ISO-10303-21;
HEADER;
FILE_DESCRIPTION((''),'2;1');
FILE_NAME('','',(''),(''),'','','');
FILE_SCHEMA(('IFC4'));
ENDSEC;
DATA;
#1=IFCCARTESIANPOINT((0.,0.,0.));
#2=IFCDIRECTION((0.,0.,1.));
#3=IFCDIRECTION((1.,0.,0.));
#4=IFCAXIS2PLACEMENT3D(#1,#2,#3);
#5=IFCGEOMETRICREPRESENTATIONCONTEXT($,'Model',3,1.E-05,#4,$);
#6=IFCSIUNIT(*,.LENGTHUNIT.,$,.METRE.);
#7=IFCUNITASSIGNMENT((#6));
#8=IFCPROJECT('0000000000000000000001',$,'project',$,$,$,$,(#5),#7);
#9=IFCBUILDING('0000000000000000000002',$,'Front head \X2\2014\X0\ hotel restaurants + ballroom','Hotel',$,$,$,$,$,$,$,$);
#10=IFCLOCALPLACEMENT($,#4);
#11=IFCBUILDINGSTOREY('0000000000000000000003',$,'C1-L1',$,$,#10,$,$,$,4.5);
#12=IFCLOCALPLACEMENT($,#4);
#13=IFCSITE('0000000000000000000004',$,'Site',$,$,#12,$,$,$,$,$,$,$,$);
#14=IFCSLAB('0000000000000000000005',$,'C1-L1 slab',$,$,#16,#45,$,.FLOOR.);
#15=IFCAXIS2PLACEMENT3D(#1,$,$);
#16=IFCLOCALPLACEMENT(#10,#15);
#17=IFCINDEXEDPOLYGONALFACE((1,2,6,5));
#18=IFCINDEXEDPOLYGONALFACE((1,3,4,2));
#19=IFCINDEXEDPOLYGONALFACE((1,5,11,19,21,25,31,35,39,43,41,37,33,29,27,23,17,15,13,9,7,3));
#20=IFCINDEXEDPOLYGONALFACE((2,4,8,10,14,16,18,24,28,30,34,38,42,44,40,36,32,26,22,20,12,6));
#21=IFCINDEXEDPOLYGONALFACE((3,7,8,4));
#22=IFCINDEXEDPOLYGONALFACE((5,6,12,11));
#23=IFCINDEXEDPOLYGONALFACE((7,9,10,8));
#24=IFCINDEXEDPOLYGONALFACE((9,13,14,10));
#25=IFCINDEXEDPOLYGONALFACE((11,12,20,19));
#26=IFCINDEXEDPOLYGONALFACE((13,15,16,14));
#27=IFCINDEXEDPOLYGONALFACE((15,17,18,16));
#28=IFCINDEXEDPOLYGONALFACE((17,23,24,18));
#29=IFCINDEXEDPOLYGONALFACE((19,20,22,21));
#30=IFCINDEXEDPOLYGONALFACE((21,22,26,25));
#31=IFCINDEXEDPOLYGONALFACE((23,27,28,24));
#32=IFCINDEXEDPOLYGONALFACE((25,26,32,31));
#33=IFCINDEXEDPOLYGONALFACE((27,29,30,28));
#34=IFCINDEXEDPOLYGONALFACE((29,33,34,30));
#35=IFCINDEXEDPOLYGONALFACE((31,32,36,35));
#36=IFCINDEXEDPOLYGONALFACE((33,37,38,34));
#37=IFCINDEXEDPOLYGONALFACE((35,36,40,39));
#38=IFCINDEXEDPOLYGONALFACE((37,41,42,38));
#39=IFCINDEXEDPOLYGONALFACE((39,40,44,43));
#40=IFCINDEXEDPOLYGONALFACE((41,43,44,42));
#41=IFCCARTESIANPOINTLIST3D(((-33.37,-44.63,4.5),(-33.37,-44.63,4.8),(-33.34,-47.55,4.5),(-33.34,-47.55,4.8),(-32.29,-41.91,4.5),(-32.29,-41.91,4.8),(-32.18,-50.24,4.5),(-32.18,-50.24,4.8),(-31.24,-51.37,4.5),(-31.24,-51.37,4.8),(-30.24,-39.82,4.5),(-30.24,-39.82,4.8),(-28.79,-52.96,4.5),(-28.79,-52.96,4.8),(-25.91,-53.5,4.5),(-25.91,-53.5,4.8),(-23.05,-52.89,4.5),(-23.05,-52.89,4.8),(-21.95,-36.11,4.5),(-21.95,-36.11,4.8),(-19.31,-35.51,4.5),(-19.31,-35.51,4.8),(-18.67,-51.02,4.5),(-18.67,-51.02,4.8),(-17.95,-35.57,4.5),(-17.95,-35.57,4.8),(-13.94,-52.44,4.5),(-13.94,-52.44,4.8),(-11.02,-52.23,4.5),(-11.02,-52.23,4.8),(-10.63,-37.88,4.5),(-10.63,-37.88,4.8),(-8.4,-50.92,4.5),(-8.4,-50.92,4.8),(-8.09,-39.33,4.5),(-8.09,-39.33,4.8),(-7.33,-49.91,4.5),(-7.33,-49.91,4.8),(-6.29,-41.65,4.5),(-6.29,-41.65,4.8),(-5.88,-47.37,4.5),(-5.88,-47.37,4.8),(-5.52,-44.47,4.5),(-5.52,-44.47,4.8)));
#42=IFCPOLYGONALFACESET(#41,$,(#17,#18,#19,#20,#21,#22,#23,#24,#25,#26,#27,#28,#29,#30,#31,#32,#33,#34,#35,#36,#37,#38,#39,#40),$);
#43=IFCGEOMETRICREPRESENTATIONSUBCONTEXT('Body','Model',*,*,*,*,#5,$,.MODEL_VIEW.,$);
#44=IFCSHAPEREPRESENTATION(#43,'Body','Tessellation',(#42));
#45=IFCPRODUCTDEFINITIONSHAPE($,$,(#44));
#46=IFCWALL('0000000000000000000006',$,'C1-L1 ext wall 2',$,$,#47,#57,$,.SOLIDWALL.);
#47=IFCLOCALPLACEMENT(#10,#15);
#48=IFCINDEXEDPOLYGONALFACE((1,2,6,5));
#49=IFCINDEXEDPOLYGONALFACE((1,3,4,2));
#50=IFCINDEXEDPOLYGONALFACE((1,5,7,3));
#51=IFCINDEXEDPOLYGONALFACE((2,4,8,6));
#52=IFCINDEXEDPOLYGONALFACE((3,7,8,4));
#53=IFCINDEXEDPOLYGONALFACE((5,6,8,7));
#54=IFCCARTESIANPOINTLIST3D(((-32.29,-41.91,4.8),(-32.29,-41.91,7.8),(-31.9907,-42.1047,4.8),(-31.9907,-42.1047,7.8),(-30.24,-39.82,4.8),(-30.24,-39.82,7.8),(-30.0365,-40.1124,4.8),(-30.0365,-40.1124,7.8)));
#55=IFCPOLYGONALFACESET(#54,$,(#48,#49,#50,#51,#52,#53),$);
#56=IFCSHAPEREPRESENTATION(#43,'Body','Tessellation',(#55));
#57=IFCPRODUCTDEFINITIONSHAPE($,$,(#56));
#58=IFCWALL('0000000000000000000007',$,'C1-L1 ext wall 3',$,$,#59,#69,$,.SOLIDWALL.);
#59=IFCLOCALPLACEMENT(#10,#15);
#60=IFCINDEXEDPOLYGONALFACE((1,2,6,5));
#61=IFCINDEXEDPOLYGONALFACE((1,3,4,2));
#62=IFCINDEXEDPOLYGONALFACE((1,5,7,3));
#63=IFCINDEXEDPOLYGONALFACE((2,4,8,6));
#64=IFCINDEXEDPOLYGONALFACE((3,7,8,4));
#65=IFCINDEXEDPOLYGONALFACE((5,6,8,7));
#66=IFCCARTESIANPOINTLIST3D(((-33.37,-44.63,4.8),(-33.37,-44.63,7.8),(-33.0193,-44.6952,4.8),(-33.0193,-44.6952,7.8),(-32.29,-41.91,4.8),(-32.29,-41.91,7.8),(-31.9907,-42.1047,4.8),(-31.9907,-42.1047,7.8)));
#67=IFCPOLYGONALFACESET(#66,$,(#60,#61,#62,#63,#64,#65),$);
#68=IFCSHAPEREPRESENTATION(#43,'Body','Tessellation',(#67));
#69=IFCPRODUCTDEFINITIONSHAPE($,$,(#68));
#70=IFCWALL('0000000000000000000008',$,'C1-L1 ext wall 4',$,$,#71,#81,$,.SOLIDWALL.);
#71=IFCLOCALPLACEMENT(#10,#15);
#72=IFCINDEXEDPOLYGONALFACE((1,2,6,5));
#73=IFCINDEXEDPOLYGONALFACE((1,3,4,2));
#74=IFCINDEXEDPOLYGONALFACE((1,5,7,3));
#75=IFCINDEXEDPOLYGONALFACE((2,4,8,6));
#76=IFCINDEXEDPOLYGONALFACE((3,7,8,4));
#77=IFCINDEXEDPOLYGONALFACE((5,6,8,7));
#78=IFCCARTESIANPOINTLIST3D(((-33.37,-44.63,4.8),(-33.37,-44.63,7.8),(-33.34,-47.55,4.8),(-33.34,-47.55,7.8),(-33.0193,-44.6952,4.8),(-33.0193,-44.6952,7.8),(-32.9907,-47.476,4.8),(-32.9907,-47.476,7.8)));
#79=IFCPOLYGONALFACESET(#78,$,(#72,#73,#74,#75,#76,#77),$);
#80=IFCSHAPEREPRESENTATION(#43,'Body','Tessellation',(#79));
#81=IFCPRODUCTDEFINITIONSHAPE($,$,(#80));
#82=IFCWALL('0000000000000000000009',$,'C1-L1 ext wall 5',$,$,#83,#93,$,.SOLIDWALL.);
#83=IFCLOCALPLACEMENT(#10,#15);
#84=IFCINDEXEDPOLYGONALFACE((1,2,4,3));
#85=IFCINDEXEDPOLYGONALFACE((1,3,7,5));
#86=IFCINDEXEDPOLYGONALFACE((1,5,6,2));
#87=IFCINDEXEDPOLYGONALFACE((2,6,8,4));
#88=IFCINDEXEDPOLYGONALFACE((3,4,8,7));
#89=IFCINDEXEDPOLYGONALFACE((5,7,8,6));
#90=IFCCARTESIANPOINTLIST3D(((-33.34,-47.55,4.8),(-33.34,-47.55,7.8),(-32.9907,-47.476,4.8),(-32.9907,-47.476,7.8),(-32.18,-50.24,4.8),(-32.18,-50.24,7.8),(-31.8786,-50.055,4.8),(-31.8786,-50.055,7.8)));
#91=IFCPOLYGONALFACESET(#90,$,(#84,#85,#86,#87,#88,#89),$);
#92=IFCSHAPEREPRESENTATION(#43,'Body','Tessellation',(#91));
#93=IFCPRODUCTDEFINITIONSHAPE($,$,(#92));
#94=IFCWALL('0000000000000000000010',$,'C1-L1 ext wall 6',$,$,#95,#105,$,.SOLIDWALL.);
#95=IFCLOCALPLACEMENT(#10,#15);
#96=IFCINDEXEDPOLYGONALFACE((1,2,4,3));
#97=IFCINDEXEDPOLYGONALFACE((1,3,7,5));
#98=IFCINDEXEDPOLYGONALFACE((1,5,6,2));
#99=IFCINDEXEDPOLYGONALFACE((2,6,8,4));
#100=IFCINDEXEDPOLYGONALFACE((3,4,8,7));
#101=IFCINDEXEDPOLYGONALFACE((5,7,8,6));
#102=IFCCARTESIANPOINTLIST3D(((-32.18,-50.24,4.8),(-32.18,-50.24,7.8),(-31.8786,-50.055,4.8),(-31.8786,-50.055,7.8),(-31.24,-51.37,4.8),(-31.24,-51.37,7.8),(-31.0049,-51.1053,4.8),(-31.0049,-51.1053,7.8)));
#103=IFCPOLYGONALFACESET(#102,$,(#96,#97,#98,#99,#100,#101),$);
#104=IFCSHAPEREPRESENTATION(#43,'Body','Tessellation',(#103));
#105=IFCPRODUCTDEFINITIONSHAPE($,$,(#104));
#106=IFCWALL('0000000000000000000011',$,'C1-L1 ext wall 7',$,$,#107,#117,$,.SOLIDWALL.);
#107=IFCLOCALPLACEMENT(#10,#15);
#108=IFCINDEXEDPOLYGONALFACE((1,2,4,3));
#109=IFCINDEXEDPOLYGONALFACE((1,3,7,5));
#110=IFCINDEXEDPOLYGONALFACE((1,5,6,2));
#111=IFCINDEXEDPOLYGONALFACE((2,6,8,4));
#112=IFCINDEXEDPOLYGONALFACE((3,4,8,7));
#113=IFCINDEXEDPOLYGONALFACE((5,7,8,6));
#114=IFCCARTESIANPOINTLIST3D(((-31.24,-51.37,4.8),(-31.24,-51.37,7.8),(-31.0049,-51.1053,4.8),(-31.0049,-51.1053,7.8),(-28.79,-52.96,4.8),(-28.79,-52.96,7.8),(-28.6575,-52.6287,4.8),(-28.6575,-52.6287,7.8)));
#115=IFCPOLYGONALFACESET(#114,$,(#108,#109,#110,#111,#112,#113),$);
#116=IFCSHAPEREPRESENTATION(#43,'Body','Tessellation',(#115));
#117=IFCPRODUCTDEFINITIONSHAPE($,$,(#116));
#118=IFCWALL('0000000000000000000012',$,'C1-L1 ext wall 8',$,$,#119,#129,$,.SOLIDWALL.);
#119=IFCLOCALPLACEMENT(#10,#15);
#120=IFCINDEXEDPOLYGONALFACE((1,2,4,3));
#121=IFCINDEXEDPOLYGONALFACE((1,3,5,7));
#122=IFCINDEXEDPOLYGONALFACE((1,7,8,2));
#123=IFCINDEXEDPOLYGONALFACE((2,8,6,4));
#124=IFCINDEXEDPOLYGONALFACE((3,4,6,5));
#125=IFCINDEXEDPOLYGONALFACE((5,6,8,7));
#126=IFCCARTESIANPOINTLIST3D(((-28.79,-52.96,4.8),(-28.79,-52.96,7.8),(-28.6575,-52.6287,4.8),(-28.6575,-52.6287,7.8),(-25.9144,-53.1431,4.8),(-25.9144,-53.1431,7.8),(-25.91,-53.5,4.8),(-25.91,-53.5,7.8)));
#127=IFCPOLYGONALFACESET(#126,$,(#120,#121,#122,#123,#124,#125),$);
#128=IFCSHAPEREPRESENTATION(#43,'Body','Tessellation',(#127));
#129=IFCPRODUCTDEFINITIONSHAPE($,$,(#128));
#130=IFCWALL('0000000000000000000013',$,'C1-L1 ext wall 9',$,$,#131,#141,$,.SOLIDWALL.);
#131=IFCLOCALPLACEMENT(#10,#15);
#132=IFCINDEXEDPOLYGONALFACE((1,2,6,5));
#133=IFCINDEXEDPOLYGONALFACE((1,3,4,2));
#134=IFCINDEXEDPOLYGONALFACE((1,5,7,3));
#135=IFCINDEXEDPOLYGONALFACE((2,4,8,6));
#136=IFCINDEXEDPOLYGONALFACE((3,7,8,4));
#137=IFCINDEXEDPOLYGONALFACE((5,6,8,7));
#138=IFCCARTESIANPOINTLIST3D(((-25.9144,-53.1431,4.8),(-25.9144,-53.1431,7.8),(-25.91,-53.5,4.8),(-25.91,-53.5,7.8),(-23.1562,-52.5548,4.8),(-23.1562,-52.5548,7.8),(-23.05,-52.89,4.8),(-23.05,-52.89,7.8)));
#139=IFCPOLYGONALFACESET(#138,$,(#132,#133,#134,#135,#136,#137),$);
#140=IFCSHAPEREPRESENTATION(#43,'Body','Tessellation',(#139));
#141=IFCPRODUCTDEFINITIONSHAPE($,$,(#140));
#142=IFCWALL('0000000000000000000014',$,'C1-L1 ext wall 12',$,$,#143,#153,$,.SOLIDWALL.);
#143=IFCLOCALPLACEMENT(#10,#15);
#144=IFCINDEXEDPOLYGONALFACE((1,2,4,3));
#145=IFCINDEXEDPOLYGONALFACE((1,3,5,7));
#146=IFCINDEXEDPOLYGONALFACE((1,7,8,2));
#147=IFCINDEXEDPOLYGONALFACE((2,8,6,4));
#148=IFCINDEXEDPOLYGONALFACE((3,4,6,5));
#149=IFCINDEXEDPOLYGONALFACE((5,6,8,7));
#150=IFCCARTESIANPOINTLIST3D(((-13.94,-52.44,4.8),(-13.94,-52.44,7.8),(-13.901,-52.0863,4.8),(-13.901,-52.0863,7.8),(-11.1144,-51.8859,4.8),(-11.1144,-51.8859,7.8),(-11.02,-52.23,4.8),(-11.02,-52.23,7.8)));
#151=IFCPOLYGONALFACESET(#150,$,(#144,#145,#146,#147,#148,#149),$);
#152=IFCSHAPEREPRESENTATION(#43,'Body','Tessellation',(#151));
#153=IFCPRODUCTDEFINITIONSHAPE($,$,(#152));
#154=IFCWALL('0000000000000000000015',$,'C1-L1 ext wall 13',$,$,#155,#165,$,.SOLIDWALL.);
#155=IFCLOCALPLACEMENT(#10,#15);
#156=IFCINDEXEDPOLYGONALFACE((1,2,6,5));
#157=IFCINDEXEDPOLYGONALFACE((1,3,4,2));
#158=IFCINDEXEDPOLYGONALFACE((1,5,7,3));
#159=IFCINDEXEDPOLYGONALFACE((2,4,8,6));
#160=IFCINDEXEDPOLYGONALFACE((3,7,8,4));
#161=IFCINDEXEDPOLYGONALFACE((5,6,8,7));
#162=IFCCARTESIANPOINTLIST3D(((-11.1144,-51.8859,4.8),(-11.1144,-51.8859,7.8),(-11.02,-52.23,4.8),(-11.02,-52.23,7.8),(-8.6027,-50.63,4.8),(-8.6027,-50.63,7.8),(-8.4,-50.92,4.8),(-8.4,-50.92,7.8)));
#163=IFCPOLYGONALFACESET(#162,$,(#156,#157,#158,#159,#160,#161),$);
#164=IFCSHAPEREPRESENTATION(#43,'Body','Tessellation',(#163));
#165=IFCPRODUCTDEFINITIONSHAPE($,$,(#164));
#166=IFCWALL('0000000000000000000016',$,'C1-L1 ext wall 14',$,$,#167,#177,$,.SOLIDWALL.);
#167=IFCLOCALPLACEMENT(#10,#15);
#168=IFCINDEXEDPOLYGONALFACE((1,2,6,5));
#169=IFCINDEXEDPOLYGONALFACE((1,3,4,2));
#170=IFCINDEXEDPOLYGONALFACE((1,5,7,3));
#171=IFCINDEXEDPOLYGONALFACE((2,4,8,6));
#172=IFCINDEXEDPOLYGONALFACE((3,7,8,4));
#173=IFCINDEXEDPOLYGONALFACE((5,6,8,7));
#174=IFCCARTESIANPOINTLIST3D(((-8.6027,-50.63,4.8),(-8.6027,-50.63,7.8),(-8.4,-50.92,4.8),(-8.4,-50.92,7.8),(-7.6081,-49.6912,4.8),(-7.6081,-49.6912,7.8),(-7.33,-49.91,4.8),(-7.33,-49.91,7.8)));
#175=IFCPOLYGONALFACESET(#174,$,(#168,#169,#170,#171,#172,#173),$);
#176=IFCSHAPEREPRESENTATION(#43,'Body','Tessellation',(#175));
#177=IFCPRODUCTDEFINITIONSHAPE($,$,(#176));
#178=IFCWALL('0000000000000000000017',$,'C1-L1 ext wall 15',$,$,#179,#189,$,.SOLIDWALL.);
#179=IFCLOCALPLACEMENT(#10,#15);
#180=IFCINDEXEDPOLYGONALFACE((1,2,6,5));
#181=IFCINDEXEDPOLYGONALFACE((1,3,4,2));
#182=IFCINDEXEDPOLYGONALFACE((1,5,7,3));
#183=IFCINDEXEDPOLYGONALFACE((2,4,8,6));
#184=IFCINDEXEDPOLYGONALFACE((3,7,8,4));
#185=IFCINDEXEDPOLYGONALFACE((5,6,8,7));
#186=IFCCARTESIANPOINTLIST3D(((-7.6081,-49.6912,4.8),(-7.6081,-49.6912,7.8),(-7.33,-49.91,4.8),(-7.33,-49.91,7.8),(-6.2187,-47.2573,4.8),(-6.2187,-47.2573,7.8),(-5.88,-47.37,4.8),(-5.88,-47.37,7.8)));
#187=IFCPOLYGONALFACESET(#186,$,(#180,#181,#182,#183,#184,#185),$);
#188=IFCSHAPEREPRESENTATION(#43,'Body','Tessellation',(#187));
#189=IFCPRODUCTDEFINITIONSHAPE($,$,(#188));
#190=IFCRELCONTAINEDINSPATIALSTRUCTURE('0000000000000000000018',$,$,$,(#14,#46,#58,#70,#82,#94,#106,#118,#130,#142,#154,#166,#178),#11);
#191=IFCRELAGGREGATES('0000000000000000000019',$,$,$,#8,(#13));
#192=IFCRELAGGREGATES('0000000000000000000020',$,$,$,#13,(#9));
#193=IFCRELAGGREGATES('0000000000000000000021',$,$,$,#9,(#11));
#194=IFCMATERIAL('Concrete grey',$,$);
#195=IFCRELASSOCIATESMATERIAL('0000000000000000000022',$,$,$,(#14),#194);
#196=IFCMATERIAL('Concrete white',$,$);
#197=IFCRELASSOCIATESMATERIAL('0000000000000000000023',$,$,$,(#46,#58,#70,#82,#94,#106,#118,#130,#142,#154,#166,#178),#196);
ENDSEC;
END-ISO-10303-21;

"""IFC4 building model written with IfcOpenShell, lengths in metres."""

from ifc_helpers import new_model, si_unit, frame, origin_with_axes, place, context, subcontext, project, spatial, polyline, outline, extrude, material, element, save


model = new_model("IFC4")

# Units and contexts
model_context = context("Model", 3, precision=1e-05, world=origin_with_axes())
body_context = subcontext(model_context, "Body", "Model", "MODEL_VIEW")
ifc_project = project(units=[si_unit("LENGTHUNIT", "METRE")], contexts=[model_context])

# Site, building, storey
site_placement = place(None, origin_with_axes())
site = spatial("IfcSite", under=ifc_project, at=site_placement, Name="Site")
building = spatial("IfcBuilding", under=site, Name="Front head — hotel restaurants + ballroom", Description="Hotel")
storey_placement = place(None, origin_with_axes())
storey = spatial("IfcBuildingStorey", under=building, at=storey_placement, Name="C1-L1", Elevation=4.5)

# Slab
ifc_material_1 = material(Name="Concrete grey")
slab_placement = place(storey_placement, origin_with_axes())
element("IfcSlab", 1, at=slab_placement, inside=storey, material=ifc_material_1, Name="C1-L1 slab", PredefinedType="FLOOR", context=body_context, shape_type="SweptSolid", body=[
    extrude(outline(polyline([(-21.95, -36.11), (-30.24, -39.82), (-32.29, -41.91), (-33.37, -44.63), (-33.34, -47.55), (-32.18, -50.24), (-31.24, -51.37), (-28.79, -52.96), (-25.91, -53.5), (-23.05, -52.89), (-18.67, -51.02), (-13.94, -52.44), (-11.02, -52.23), (-8.4, -50.92), (-7.33, -49.91), (-5.88, -47.37), (-5.52, -44.47), (-6.29, -41.65), (-8.09, -39.33), (-10.63, -37.88), (-17.95, -35.57), (-19.31, -35.51), (-21.95, -36.11)])), frame((0.0, 0.0, 4.5), z_axis=(0.0, 0.0, 1.0), x_axis=(1.0, 0.0, 0.0)), (0.0, 0.0, 1.0), 0.3),
])

# Shared definitions
ifc_material_2 = material(Name="Concrete white")

# Walls
wall_1_placement = place(storey_placement, origin_with_axes())
element("IfcWall", 2, at=wall_1_placement, inside=storey, material=ifc_material_2, Name="C1-L1 ext wall 2", PredefinedType="SOLIDWALL", context=body_context, shape_type="SweptSolid", body=[
    extrude(outline(polyline([(-30.24, -39.82), (-32.29, -41.91), (-31.9907, -42.1047), (-30.0365, -40.1124), (-30.24, -39.82)])), frame((0.0, 0.0, 4.8), z_axis=(0.0, 0.0, 1.0), x_axis=(1.0, 0.0, 0.0)), (0.0, 0.0, 1.0), 3.0),
])
wall_2_placement = place(storey_placement, origin_with_axes())
element("IfcWall", 3, at=wall_2_placement, inside=storey, material=ifc_material_2, Name="C1-L1 ext wall 3", PredefinedType="SOLIDWALL", context=body_context, shape_type="SweptSolid", body=[
    extrude(outline(polyline([(-32.29, -41.91), (-33.37, -44.63), (-33.0193, -44.6952), (-31.9907, -42.1047), (-32.29, -41.91)])), frame((0.0, 0.0, 4.8), z_axis=(0.0, 0.0, 1.0), x_axis=(1.0, 0.0, 0.0)), (0.0, 0.0, 1.0), 3.0),
])
wall_3_placement = place(storey_placement, origin_with_axes())
element("IfcWall", 4, at=wall_3_placement, inside=storey, material=ifc_material_2, Name="C1-L1 ext wall 4", PredefinedType="SOLIDWALL", context=body_context, shape_type="SweptSolid", body=[
    extrude(outline(polyline([(-33.37, -44.63), (-33.34, -47.55), (-32.9907, -47.476), (-33.0193, -44.6952), (-33.37, -44.63)])), frame((0.0, 0.0, 4.8), z_axis=(0.0, 0.0, 1.0), x_axis=(1.0, 0.0, 0.0)), (0.0, 0.0, 1.0), 3.0),
])
wall_4_placement = place(storey_placement, origin_with_axes())
element("IfcWall", 5, at=wall_4_placement, inside=storey, material=ifc_material_2, Name="C1-L1 ext wall 5", PredefinedType="SOLIDWALL", context=body_context, shape_type="SweptSolid", body=[
    extrude(outline(polyline([(-33.34, -47.55), (-32.18, -50.24), (-31.8786, -50.055), (-32.9907, -47.476), (-33.34, -47.55)])), frame((0.0, 0.0, 4.8), z_axis=(0.0, 0.0, 1.0), x_axis=(1.0, 0.0, 0.0)), (0.0, 0.0, 1.0), 3.0),
])
wall_5_placement = place(storey_placement, origin_with_axes())
element("IfcWall", 6, at=wall_5_placement, inside=storey, material=ifc_material_2, Name="C1-L1 ext wall 6", PredefinedType="SOLIDWALL", context=body_context, shape_type="SweptSolid", body=[
    extrude(outline(polyline([(-32.18, -50.24), (-31.24, -51.37), (-31.0049, -51.1053), (-31.8786, -50.055), (-32.18, -50.24)])), frame((0.0, 0.0, 4.8), z_axis=(0.0, 0.0, 1.0), x_axis=(1.0, 0.0, 0.0)), (0.0, 0.0, 1.0), 3.0),
])
wall_6_placement = place(storey_placement, origin_with_axes())
element("IfcWall", 7, at=wall_6_placement, inside=storey, material=ifc_material_2, Name="C1-L1 ext wall 7", PredefinedType="SOLIDWALL", context=body_context, shape_type="SweptSolid", body=[
    extrude(outline(polyline([(-31.24, -51.37), (-28.79, -52.96), (-28.6575, -52.6287), (-31.0049, -51.1053), (-31.24, -51.37)])), frame((0.0, 0.0, 4.8), z_axis=(0.0, 0.0, 1.0), x_axis=(1.0, 0.0, 0.0)), (0.0, 0.0, 1.0), 3.0),
])
wall_7_placement = place(storey_placement, origin_with_axes())
element("IfcWall", 8, at=wall_7_placement, inside=storey, material=ifc_material_2, Name="C1-L1 ext wall 8", PredefinedType="SOLIDWALL", context=body_context, shape_type="SweptSolid", body=[
    extrude(outline(polyline([(-28.79, -52.96), (-25.91, -53.5), (-25.9144, -53.1431), (-28.6575, -52.6287), (-28.79, -52.96)])), frame((0.0, 0.0, 4.8), z_axis=(0.0, 0.0, 1.0), x_axis=(1.0, 0.0, 0.0)), (0.0, 0.0, 1.0), 3.0),
])
wall_8_placement = place(storey_placement, origin_with_axes())
element("IfcWall", 9, at=wall_8_placement, inside=storey, material=ifc_material_2, Name="C1-L1 ext wall 9", PredefinedType="SOLIDWALL", context=body_context, shape_type="SweptSolid", body=[
    extrude(outline(polyline([(-25.91, -53.5), (-23.05, -52.89), (-23.1562, -52.5548), (-25.9144, -53.1431), (-25.91, -53.5)])), frame((0.0, 0.0, 4.8), z_axis=(0.0, 0.0, 1.0), x_axis=(1.0, 0.0, 0.0)), (0.0, 0.0, 1.0), 3.0),
])

# Walls
wall_9_placement = place(storey_placement, origin_with_axes())
element("IfcWall", 10, at=wall_9_placement, inside=storey, material=ifc_material_2, Name="C1-L1 ext wall 12", PredefinedType="SOLIDWALL", context=body_context, shape_type="SweptSolid", body=[
    extrude(outline(polyline([(-13.94, -52.44), (-11.02, -52.23), (-11.1144, -51.8859), (-13.901, -52.0863), (-13.94, -52.44)])), frame((0.0, 0.0, 4.8), z_axis=(0.0, 0.0, 1.0), x_axis=(1.0, 0.0, 0.0)), (0.0, 0.0, 1.0), 3.0),
])
wall_10_placement = place(storey_placement, origin_with_axes())
element("IfcWall", 11, at=wall_10_placement, inside=storey, material=ifc_material_2, Name="C1-L1 ext wall 13", PredefinedType="SOLIDWALL", context=body_context, shape_type="SweptSolid", body=[
    extrude(outline(polyline([(-11.02, -52.23), (-8.4, -50.92), (-8.6027, -50.63), (-11.1144, -51.8859), (-11.02, -52.23)])), frame((0.0, 0.0, 4.8), z_axis=(0.0, 0.0, 1.0), x_axis=(1.0, 0.0, 0.0)), (0.0, 0.0, 1.0), 3.0),
])
wall_11_placement = place(storey_placement, origin_with_axes())
element("IfcWall", 12, at=wall_11_placement, inside=storey, material=ifc_material_2, Name="C1-L1 ext wall 14", PredefinedType="SOLIDWALL", context=body_context, shape_type="SweptSolid", body=[
    extrude(outline(polyline([(-8.4, -50.92), (-7.33, -49.91), (-7.6081, -49.6912), (-8.6027, -50.63), (-8.4, -50.92)])), frame((0.0, 0.0, 4.8), z_axis=(0.0, 0.0, 1.0), x_axis=(1.0, 0.0, 0.0)), (0.0, 0.0, 1.0), 3.0),
])
wall_12_placement = place(storey_placement, origin_with_axes())
element("IfcWall", 13, at=wall_12_placement, inside=storey, material=ifc_material_2, Name="C1-L1 ext wall 15", PredefinedType="SOLIDWALL", context=body_context, shape_type="SweptSolid", body=[
    extrude(outline(polyline([(-7.33, -49.91), (-5.88, -47.37), (-6.2187, -47.2573), (-7.6081, -49.6912), (-7.33, -49.91)])), frame((0.0, 0.0, 4.8), z_axis=(0.0, 0.0, 1.0), x_axis=(1.0, 0.0, 0.0)), (0.0, 0.0, 1.0), 3.0),
])

save(model, "model.ifc")
